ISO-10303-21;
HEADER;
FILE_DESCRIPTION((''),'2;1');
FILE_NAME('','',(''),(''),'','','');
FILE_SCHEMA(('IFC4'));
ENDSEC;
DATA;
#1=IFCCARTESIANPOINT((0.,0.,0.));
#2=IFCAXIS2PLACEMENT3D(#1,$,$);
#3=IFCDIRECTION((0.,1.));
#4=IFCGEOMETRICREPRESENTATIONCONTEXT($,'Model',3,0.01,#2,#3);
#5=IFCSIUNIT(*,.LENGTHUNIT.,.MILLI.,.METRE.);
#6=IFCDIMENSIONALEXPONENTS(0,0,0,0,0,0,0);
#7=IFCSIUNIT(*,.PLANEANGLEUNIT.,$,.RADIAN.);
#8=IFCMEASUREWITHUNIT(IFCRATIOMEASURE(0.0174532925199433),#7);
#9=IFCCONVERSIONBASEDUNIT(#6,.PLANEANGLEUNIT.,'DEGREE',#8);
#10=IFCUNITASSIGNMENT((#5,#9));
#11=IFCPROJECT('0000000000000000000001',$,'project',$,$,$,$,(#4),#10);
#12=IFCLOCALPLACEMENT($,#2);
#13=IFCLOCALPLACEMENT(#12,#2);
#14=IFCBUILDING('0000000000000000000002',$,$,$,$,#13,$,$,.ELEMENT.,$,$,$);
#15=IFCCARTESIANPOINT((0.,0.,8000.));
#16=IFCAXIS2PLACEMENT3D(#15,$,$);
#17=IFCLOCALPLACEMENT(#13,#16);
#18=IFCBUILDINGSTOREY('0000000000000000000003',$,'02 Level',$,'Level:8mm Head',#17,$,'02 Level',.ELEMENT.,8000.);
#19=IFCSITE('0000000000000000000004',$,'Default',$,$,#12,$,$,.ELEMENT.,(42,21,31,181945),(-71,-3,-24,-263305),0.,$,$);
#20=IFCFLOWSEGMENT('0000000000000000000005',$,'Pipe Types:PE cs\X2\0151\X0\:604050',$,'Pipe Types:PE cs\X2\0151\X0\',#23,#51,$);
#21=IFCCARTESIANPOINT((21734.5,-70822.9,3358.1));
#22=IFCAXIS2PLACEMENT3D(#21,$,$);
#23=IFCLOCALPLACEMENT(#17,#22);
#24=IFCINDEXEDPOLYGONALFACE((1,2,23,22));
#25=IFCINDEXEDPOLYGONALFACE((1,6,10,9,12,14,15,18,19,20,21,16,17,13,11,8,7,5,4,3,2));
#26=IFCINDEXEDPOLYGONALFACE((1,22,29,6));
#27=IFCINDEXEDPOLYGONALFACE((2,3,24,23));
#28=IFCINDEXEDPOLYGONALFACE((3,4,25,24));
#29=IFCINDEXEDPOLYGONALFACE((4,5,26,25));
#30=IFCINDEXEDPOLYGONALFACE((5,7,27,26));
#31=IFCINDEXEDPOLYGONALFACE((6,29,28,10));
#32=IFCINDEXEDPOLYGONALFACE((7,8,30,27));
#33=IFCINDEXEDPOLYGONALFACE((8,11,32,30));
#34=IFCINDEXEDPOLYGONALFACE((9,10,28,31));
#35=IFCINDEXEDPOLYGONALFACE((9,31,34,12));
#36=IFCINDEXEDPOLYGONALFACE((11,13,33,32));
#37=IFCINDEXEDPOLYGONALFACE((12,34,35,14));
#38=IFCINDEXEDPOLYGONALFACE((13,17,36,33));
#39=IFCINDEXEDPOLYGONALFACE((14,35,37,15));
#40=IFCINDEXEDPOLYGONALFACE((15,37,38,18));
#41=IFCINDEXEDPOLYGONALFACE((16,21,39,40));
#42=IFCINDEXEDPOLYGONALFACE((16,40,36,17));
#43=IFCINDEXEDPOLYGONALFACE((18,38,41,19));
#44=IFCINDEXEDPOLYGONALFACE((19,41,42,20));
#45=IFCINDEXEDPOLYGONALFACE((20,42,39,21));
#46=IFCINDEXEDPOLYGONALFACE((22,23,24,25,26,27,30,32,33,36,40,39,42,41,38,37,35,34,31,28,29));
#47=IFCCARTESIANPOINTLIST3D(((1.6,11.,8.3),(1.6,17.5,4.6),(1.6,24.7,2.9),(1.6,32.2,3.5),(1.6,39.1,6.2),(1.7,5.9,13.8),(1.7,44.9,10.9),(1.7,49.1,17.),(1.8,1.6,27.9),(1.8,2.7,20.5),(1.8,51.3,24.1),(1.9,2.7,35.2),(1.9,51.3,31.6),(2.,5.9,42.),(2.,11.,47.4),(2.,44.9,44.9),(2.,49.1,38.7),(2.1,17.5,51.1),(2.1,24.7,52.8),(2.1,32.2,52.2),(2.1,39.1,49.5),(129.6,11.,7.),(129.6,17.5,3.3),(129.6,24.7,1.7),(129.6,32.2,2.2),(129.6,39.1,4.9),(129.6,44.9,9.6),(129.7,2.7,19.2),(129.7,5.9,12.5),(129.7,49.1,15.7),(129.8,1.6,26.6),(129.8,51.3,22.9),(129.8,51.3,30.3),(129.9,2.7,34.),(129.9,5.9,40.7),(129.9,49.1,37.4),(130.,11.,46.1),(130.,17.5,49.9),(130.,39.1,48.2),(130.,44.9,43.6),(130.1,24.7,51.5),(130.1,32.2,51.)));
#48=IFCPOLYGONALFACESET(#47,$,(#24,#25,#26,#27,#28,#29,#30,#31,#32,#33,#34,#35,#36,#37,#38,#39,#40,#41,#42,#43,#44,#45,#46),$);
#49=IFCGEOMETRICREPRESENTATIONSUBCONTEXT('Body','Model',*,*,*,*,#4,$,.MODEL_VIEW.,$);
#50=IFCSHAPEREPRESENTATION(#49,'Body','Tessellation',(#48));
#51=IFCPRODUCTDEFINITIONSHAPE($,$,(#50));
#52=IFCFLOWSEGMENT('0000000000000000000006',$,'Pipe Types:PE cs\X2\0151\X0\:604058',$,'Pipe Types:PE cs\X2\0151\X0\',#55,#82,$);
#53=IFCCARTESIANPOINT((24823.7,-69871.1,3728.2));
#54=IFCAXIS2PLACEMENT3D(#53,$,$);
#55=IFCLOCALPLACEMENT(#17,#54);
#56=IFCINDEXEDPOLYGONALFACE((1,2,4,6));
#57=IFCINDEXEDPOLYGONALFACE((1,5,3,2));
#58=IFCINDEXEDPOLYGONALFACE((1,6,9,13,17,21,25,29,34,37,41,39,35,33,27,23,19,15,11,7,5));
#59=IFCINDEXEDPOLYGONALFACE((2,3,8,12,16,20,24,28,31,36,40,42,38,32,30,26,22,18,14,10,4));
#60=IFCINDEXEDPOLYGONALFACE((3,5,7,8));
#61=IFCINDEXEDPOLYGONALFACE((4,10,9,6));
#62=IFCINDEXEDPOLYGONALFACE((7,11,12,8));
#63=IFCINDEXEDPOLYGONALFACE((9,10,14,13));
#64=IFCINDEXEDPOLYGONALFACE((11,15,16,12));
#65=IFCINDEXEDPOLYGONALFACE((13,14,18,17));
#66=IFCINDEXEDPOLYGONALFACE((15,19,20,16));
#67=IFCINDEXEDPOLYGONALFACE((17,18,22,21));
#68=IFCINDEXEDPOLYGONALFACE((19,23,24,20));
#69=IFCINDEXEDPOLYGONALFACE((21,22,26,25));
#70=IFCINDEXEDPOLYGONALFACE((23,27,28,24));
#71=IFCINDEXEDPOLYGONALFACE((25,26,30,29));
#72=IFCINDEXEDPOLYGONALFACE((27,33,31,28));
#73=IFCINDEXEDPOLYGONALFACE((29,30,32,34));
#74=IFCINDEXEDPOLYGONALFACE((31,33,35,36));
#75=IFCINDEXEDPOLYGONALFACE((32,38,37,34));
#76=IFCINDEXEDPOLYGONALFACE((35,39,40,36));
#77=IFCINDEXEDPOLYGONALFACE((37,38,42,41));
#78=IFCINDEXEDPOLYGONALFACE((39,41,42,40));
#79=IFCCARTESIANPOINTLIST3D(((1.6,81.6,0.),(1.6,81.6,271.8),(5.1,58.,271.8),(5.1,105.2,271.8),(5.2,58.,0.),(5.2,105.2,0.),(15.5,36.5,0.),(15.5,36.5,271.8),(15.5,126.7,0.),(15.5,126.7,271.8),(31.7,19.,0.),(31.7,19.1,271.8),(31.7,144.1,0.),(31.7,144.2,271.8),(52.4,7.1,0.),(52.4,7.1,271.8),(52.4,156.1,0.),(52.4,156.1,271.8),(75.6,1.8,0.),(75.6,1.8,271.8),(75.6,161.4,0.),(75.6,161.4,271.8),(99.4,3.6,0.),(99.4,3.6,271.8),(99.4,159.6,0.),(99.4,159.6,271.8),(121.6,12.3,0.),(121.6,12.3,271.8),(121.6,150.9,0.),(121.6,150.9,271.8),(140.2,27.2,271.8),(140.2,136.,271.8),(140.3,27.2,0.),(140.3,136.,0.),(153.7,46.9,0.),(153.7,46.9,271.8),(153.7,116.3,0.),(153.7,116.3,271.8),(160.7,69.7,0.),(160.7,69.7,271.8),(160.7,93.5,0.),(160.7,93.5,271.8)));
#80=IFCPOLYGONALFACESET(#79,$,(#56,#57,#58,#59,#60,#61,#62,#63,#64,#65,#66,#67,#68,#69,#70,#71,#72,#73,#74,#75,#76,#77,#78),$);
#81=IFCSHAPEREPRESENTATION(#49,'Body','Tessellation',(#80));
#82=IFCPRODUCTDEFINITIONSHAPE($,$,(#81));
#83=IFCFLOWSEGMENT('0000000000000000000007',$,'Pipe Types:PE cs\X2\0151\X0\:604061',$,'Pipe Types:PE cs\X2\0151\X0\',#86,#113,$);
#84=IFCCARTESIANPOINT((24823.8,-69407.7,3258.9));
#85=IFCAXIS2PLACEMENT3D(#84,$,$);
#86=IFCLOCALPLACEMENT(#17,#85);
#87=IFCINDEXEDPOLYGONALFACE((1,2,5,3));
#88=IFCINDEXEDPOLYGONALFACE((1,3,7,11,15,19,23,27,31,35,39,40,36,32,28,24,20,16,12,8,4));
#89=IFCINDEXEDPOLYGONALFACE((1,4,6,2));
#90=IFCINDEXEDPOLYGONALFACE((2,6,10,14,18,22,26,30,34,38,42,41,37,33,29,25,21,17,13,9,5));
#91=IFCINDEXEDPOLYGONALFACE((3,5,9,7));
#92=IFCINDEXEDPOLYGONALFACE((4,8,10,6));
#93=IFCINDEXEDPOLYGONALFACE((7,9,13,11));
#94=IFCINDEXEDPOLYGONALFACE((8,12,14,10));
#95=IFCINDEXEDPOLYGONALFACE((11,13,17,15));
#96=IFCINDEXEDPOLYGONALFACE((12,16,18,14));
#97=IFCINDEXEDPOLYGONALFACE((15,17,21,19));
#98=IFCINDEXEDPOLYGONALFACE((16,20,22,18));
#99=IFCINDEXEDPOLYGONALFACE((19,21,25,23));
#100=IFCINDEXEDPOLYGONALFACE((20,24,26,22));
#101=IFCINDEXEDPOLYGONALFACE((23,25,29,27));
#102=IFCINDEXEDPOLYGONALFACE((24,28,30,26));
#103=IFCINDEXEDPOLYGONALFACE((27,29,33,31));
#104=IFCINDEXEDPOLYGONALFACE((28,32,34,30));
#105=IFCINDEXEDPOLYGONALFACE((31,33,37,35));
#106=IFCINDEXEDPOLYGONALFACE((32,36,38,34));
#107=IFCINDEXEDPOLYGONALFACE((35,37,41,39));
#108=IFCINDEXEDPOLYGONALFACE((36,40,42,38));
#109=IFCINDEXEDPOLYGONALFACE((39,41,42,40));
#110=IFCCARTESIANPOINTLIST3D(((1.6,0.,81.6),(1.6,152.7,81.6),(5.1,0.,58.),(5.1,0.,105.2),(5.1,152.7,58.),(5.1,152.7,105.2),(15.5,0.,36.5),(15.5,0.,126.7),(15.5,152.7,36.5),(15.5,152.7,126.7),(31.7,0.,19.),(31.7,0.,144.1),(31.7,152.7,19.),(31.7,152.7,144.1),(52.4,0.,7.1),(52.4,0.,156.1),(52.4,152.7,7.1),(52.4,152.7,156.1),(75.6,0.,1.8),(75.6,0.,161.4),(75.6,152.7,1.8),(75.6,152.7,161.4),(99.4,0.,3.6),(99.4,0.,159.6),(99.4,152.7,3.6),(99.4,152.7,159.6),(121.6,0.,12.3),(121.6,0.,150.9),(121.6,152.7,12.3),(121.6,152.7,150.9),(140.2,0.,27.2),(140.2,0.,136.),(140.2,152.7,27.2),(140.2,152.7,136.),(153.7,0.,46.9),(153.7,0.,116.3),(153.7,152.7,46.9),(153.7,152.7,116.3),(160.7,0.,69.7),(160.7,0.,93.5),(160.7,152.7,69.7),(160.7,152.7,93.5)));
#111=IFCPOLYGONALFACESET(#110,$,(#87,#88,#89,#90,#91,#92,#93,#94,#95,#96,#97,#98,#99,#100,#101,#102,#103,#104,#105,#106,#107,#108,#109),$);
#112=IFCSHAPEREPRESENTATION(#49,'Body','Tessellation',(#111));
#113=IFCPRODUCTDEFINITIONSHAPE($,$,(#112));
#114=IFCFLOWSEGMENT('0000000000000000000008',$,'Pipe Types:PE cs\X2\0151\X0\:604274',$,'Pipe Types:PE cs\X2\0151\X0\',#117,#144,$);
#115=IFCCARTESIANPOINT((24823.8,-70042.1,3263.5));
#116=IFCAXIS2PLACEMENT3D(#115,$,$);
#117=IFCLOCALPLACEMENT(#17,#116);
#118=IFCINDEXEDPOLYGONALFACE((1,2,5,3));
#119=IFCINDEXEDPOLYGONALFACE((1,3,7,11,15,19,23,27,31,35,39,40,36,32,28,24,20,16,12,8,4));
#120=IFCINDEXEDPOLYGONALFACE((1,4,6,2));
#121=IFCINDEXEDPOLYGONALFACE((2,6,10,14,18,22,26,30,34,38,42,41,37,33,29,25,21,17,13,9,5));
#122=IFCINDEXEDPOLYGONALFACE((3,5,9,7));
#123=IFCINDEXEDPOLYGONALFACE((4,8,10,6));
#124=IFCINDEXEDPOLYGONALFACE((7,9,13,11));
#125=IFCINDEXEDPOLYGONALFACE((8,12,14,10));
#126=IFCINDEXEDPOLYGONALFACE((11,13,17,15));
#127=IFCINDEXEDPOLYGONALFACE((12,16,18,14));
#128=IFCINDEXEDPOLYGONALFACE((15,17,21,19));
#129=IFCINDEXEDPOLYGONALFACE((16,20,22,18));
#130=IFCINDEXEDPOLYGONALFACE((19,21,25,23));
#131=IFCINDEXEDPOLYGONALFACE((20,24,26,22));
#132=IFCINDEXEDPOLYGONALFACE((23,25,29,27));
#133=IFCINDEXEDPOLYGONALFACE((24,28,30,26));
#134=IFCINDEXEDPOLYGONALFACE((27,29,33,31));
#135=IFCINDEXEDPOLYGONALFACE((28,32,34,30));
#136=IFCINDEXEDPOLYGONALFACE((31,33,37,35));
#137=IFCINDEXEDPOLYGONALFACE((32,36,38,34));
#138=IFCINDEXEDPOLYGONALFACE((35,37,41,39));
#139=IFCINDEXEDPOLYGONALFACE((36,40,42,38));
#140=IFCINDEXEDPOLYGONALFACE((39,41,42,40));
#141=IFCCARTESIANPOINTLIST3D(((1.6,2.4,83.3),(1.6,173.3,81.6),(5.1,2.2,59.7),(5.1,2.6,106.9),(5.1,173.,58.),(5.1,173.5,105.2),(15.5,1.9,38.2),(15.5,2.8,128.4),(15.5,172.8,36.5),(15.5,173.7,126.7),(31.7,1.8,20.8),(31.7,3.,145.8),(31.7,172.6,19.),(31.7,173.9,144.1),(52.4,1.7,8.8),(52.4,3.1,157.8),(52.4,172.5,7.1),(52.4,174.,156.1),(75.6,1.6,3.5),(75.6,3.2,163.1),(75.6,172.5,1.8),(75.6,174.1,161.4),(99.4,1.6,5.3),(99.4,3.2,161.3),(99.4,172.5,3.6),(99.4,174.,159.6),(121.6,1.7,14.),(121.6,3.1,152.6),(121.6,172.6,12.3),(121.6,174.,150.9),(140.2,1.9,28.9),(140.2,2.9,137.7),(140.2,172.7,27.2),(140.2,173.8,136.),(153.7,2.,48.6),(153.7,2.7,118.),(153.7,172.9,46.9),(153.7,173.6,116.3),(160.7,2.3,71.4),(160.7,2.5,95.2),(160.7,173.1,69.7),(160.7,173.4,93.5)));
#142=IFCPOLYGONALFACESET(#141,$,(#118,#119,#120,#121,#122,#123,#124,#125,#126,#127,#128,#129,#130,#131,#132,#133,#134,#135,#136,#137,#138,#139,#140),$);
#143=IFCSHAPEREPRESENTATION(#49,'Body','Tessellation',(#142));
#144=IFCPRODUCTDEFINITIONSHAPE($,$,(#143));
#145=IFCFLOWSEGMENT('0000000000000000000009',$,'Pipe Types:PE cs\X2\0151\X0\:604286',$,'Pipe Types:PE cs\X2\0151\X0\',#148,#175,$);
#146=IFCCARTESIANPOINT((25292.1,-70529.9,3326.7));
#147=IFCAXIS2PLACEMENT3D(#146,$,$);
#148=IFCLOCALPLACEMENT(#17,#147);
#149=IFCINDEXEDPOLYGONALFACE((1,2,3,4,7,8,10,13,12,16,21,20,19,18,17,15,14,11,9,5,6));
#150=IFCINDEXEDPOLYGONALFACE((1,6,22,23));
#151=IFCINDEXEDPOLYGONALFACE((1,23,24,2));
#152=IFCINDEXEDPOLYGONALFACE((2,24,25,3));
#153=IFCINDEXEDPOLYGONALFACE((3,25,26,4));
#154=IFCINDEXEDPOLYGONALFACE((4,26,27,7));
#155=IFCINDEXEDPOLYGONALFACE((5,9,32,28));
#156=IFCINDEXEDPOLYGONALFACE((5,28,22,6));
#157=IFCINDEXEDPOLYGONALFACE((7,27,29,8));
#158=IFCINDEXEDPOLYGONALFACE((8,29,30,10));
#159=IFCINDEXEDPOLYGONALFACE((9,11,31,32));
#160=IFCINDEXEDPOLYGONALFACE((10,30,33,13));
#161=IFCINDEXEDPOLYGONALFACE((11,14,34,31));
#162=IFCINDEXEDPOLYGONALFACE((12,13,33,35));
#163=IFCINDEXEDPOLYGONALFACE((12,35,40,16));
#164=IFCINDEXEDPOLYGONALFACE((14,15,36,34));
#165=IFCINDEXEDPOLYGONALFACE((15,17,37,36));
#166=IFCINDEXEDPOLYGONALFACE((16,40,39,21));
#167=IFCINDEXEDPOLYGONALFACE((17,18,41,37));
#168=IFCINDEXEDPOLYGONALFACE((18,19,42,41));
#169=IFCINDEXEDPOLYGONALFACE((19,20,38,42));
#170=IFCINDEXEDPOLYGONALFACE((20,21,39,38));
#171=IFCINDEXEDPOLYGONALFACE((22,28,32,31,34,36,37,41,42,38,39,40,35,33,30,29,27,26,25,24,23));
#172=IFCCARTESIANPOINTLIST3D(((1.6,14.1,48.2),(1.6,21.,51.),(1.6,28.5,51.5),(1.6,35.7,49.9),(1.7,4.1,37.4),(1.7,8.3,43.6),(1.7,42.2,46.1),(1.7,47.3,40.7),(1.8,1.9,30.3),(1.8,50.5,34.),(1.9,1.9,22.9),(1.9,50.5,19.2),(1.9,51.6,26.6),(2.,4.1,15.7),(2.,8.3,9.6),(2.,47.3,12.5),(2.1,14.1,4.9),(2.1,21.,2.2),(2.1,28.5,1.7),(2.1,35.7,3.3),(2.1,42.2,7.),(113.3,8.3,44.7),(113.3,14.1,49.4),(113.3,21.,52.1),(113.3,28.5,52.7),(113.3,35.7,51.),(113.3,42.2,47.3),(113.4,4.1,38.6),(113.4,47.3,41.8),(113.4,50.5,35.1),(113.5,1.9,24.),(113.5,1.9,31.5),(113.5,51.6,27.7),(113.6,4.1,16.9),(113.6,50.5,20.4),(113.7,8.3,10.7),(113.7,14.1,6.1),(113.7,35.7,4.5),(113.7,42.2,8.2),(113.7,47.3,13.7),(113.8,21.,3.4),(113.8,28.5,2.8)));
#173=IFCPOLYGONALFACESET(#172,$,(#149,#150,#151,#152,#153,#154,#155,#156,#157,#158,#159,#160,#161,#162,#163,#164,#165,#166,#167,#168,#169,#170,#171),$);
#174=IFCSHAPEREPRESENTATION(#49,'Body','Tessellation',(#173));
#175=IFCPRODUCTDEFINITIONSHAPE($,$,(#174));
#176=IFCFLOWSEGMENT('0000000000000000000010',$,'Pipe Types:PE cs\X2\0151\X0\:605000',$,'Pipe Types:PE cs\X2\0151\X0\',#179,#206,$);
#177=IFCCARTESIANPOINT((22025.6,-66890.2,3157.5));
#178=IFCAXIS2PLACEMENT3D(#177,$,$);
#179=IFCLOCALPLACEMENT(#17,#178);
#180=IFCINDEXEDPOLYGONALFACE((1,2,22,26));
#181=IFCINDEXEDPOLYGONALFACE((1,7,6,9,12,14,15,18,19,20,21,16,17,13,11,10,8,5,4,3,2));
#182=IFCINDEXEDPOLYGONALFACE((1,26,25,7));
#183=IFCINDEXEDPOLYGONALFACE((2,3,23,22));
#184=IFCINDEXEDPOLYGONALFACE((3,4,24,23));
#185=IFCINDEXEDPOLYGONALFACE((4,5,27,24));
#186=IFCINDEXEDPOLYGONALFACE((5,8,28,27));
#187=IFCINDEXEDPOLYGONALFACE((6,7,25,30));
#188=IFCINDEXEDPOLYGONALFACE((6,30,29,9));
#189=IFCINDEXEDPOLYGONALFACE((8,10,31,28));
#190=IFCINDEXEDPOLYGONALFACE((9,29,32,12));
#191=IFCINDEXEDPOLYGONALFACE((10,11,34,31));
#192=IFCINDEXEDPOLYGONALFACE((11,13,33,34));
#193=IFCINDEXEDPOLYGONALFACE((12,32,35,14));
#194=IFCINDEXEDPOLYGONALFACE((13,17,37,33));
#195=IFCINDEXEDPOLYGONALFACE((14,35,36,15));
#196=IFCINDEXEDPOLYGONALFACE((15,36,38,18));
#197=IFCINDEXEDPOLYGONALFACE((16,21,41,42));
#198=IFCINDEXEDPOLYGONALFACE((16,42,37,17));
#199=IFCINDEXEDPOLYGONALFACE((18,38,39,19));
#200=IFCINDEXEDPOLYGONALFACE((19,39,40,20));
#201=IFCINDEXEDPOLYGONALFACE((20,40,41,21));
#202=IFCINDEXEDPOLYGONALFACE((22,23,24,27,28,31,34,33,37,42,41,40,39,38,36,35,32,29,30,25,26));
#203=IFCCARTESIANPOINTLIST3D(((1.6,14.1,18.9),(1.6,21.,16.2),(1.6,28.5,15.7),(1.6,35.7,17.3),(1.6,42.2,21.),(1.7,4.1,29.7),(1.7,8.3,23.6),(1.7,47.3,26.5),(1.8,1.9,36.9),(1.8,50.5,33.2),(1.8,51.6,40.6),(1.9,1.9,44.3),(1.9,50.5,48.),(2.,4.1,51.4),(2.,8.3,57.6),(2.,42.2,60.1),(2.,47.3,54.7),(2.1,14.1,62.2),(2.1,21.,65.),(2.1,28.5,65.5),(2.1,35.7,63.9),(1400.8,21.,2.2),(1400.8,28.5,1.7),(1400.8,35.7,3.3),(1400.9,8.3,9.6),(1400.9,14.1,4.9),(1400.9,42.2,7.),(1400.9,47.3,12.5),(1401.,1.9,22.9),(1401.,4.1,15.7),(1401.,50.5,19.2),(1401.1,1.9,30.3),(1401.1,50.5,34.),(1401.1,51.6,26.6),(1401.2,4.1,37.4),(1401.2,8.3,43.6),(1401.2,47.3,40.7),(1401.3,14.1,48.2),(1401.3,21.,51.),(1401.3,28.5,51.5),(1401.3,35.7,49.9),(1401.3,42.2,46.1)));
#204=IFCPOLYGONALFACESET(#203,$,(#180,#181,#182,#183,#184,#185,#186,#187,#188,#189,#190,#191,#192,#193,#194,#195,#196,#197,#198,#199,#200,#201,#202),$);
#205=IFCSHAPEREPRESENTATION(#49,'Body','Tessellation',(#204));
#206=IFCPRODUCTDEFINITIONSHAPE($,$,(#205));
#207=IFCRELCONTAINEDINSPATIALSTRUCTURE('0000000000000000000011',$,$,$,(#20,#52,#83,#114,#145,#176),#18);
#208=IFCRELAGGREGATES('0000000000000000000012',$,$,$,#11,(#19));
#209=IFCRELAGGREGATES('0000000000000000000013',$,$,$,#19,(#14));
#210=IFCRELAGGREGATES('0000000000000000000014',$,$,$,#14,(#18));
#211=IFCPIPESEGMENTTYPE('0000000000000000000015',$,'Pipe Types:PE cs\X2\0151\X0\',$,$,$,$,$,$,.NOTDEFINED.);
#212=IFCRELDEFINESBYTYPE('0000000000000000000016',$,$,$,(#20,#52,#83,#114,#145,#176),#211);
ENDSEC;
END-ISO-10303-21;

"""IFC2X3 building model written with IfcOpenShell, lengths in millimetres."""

from ifc_helpers import new_model, entity, si_unit, converted_unit, direction, frame, frame_2d, origin, origin_2d_with_axis, place, context, subcontext, project, spatial, circle, extrude, type_object, element, save


model = new_model("IFC2X3")

# Units and contexts
model_context = context("Model", 3, precision=0.01, world=origin(), true_north=direction((0.0, 1.0)))
body_context = subcontext(model_context, "Body", "Model", "MODEL_VIEW")
ifc_project = project(units=[si_unit("LENGTHUNIT", "METRE", prefix="MILLI"), converted_unit("PLANEANGLEUNIT", "DEGREE", entity("IfcRatioMeasure", 0.0174532925199433), si_unit("PLANEANGLEUNIT", "RADIAN"), dimensions=[0, 0, 0, 0, 0, 0, 0])], contexts=[model_context])

# Site, building, storey
site_placement = place(None, origin())
site = spatial("IfcSite", under=ifc_project, at=site_placement, Name="Default", CompositionType="ELEMENT", RefLatitude=(42, 21, 31, 181945), RefLongitude=(-71, -3, -24, -263305), RefElevation=0.0)
building_placement = place(site_placement, origin())
building = spatial("IfcBuilding", under=site, at=building_placement, CompositionType="ELEMENT")
storey_placement = place(building_placement, frame((0.0, 0.0, 8000.0)))
storey = spatial("IfcBuildingStorey", under=building, at=storey_placement, Name="02 Level", ObjectType="Level:8mm Head", LongName="02 Level", CompositionType="ELEMENT", Elevation=8000.0)

# Flow segments
pipe_segment_type = type_object("IfcPipeSegmentType", Name="Pipe Types:PE cső", PredefinedType="NOTDEFINED")
flow_segment_1_placement = place(storey_placement, frame((21734.5, -70822.9, 3358.1)))
element("IfcFlowSegment", 1, at=flow_segment_1_placement, inside=storey, type_object=pipe_segment_type, Name="Pipe Types:PE cső:604050", ObjectType="Pipe Types:PE cső", context=body_context, shape_type="SweptSolid", body=[
    extrude(circle(Radius=25.0, at=frame_2d((0.0, 0.0), x_axis=(1.0, 0.0))), frame((129.8, 26.6, 26.6), z_axis=(-0.99995, 0.0, 0.01), x_axis=(0.0, -1.0, 0.0)), (0.0, 0.0, 1.0), 128.0),
])
flow_segment_2_placement = place(storey_placement, frame((24823.7, -69871.1, 3728.2)))
element("IfcFlowSegment", 2, at=flow_segment_2_placement, inside=storey, type_object=pipe_segment_type, Name="Pipe Types:PE cső:604058", ObjectType="Pipe Types:PE cső", context=body_context, shape_type="SweptSolid", body=[
    extrude(circle(Radius=80.0, at=origin_2d_with_axis()), frame((81.6, 81.6, 0.0), z_axis=(-0.000102, 0.00007, 1.0), x_axis=(-1.0, 0.0, -0.000102)), (0.0, 0.0, 1.0), 271.8),
])
flow_segment_3_placement = place(storey_placement, frame((24823.8, -69407.7, 3258.9)))
element("IfcFlowSegment", 3, at=flow_segment_3_placement, inside=storey, type_object=pipe_segment_type, Name="Pipe Types:PE cső:604061", ObjectType="Pipe Types:PE cső", context=body_context, shape_type="SweptSolid", body=[
    extrude(circle(Radius=80.0, at=origin_2d_with_axis()), frame((81.6, 0.0, 81.6), z_axis=(0.0, 1.0, 0.0), x_axis=(-1.0, 0.0, 0.0)), (0.0, 0.0, 1.0), 152.7),
])
flow_segment_4_placement = place(storey_placement, frame((24823.8, -70042.1, 3263.5)))
element("IfcFlowSegment", 4, at=flow_segment_4_placement, inside=storey, type_object=pipe_segment_type, Name="Pipe Types:PE cső:604274", ObjectType="Pipe Types:PE cső", context=body_context, shape_type="SweptSolid", body=[
    extrude(circle(Radius=80.0, at=origin_2d_with_axis()), frame((81.6, 2.4, 83.3), z_axis=(0.0, 0.99995, -0.01), x_axis=(-1.0, 0.0, 0.0)), (0.0, 0.0, 1.0), 170.9),
])
flow_segment_5_placement = place(storey_placement, frame((25292.1, -70529.9, 3326.7)))
element("IfcFlowSegment", 5, at=flow_segment_5_placement, inside=storey, type_object=pipe_segment_type, Name="Pipe Types:PE cső:604286", ObjectType="Pipe Types:PE cső", context=body_context, shape_type="SweptSolid", body=[
    extrude(circle(Radius=25.0, at=frame_2d((0.0, 0.0), x_axis=(1.0, 0.0))), frame((113.5, 26.6, 27.7), z_axis=(-0.999948, 0.000032, -0.010203), x_axis=(0.000032, 1.0, 0.0)), (0.0, 0.0, 1.0), 111.7),
])
flow_segment_6_placement = place(storey_placement, frame((22025.6, -66890.2, 3157.5)))
element("IfcFlowSegment", 6, at=flow_segment_6_placement, inside=storey, type_object=pipe_segment_type, Name="Pipe Types:PE cső:605000", ObjectType="Pipe Types:PE cső", context=body_context, shape_type="SweptSolid", body=[
    extrude(circle(Radius=25.0, at=frame_2d((0.0, 0.0), x_axis=(1.0, 0.0))), frame((1.8, 26.6, 40.6), z_axis=(0.99995, 0.0, -0.01), x_axis=(0.0, 1.0, 0.0)), (0.0, 0.0, 1.0), 1399.3),
])

save(model, "model.ifc")
